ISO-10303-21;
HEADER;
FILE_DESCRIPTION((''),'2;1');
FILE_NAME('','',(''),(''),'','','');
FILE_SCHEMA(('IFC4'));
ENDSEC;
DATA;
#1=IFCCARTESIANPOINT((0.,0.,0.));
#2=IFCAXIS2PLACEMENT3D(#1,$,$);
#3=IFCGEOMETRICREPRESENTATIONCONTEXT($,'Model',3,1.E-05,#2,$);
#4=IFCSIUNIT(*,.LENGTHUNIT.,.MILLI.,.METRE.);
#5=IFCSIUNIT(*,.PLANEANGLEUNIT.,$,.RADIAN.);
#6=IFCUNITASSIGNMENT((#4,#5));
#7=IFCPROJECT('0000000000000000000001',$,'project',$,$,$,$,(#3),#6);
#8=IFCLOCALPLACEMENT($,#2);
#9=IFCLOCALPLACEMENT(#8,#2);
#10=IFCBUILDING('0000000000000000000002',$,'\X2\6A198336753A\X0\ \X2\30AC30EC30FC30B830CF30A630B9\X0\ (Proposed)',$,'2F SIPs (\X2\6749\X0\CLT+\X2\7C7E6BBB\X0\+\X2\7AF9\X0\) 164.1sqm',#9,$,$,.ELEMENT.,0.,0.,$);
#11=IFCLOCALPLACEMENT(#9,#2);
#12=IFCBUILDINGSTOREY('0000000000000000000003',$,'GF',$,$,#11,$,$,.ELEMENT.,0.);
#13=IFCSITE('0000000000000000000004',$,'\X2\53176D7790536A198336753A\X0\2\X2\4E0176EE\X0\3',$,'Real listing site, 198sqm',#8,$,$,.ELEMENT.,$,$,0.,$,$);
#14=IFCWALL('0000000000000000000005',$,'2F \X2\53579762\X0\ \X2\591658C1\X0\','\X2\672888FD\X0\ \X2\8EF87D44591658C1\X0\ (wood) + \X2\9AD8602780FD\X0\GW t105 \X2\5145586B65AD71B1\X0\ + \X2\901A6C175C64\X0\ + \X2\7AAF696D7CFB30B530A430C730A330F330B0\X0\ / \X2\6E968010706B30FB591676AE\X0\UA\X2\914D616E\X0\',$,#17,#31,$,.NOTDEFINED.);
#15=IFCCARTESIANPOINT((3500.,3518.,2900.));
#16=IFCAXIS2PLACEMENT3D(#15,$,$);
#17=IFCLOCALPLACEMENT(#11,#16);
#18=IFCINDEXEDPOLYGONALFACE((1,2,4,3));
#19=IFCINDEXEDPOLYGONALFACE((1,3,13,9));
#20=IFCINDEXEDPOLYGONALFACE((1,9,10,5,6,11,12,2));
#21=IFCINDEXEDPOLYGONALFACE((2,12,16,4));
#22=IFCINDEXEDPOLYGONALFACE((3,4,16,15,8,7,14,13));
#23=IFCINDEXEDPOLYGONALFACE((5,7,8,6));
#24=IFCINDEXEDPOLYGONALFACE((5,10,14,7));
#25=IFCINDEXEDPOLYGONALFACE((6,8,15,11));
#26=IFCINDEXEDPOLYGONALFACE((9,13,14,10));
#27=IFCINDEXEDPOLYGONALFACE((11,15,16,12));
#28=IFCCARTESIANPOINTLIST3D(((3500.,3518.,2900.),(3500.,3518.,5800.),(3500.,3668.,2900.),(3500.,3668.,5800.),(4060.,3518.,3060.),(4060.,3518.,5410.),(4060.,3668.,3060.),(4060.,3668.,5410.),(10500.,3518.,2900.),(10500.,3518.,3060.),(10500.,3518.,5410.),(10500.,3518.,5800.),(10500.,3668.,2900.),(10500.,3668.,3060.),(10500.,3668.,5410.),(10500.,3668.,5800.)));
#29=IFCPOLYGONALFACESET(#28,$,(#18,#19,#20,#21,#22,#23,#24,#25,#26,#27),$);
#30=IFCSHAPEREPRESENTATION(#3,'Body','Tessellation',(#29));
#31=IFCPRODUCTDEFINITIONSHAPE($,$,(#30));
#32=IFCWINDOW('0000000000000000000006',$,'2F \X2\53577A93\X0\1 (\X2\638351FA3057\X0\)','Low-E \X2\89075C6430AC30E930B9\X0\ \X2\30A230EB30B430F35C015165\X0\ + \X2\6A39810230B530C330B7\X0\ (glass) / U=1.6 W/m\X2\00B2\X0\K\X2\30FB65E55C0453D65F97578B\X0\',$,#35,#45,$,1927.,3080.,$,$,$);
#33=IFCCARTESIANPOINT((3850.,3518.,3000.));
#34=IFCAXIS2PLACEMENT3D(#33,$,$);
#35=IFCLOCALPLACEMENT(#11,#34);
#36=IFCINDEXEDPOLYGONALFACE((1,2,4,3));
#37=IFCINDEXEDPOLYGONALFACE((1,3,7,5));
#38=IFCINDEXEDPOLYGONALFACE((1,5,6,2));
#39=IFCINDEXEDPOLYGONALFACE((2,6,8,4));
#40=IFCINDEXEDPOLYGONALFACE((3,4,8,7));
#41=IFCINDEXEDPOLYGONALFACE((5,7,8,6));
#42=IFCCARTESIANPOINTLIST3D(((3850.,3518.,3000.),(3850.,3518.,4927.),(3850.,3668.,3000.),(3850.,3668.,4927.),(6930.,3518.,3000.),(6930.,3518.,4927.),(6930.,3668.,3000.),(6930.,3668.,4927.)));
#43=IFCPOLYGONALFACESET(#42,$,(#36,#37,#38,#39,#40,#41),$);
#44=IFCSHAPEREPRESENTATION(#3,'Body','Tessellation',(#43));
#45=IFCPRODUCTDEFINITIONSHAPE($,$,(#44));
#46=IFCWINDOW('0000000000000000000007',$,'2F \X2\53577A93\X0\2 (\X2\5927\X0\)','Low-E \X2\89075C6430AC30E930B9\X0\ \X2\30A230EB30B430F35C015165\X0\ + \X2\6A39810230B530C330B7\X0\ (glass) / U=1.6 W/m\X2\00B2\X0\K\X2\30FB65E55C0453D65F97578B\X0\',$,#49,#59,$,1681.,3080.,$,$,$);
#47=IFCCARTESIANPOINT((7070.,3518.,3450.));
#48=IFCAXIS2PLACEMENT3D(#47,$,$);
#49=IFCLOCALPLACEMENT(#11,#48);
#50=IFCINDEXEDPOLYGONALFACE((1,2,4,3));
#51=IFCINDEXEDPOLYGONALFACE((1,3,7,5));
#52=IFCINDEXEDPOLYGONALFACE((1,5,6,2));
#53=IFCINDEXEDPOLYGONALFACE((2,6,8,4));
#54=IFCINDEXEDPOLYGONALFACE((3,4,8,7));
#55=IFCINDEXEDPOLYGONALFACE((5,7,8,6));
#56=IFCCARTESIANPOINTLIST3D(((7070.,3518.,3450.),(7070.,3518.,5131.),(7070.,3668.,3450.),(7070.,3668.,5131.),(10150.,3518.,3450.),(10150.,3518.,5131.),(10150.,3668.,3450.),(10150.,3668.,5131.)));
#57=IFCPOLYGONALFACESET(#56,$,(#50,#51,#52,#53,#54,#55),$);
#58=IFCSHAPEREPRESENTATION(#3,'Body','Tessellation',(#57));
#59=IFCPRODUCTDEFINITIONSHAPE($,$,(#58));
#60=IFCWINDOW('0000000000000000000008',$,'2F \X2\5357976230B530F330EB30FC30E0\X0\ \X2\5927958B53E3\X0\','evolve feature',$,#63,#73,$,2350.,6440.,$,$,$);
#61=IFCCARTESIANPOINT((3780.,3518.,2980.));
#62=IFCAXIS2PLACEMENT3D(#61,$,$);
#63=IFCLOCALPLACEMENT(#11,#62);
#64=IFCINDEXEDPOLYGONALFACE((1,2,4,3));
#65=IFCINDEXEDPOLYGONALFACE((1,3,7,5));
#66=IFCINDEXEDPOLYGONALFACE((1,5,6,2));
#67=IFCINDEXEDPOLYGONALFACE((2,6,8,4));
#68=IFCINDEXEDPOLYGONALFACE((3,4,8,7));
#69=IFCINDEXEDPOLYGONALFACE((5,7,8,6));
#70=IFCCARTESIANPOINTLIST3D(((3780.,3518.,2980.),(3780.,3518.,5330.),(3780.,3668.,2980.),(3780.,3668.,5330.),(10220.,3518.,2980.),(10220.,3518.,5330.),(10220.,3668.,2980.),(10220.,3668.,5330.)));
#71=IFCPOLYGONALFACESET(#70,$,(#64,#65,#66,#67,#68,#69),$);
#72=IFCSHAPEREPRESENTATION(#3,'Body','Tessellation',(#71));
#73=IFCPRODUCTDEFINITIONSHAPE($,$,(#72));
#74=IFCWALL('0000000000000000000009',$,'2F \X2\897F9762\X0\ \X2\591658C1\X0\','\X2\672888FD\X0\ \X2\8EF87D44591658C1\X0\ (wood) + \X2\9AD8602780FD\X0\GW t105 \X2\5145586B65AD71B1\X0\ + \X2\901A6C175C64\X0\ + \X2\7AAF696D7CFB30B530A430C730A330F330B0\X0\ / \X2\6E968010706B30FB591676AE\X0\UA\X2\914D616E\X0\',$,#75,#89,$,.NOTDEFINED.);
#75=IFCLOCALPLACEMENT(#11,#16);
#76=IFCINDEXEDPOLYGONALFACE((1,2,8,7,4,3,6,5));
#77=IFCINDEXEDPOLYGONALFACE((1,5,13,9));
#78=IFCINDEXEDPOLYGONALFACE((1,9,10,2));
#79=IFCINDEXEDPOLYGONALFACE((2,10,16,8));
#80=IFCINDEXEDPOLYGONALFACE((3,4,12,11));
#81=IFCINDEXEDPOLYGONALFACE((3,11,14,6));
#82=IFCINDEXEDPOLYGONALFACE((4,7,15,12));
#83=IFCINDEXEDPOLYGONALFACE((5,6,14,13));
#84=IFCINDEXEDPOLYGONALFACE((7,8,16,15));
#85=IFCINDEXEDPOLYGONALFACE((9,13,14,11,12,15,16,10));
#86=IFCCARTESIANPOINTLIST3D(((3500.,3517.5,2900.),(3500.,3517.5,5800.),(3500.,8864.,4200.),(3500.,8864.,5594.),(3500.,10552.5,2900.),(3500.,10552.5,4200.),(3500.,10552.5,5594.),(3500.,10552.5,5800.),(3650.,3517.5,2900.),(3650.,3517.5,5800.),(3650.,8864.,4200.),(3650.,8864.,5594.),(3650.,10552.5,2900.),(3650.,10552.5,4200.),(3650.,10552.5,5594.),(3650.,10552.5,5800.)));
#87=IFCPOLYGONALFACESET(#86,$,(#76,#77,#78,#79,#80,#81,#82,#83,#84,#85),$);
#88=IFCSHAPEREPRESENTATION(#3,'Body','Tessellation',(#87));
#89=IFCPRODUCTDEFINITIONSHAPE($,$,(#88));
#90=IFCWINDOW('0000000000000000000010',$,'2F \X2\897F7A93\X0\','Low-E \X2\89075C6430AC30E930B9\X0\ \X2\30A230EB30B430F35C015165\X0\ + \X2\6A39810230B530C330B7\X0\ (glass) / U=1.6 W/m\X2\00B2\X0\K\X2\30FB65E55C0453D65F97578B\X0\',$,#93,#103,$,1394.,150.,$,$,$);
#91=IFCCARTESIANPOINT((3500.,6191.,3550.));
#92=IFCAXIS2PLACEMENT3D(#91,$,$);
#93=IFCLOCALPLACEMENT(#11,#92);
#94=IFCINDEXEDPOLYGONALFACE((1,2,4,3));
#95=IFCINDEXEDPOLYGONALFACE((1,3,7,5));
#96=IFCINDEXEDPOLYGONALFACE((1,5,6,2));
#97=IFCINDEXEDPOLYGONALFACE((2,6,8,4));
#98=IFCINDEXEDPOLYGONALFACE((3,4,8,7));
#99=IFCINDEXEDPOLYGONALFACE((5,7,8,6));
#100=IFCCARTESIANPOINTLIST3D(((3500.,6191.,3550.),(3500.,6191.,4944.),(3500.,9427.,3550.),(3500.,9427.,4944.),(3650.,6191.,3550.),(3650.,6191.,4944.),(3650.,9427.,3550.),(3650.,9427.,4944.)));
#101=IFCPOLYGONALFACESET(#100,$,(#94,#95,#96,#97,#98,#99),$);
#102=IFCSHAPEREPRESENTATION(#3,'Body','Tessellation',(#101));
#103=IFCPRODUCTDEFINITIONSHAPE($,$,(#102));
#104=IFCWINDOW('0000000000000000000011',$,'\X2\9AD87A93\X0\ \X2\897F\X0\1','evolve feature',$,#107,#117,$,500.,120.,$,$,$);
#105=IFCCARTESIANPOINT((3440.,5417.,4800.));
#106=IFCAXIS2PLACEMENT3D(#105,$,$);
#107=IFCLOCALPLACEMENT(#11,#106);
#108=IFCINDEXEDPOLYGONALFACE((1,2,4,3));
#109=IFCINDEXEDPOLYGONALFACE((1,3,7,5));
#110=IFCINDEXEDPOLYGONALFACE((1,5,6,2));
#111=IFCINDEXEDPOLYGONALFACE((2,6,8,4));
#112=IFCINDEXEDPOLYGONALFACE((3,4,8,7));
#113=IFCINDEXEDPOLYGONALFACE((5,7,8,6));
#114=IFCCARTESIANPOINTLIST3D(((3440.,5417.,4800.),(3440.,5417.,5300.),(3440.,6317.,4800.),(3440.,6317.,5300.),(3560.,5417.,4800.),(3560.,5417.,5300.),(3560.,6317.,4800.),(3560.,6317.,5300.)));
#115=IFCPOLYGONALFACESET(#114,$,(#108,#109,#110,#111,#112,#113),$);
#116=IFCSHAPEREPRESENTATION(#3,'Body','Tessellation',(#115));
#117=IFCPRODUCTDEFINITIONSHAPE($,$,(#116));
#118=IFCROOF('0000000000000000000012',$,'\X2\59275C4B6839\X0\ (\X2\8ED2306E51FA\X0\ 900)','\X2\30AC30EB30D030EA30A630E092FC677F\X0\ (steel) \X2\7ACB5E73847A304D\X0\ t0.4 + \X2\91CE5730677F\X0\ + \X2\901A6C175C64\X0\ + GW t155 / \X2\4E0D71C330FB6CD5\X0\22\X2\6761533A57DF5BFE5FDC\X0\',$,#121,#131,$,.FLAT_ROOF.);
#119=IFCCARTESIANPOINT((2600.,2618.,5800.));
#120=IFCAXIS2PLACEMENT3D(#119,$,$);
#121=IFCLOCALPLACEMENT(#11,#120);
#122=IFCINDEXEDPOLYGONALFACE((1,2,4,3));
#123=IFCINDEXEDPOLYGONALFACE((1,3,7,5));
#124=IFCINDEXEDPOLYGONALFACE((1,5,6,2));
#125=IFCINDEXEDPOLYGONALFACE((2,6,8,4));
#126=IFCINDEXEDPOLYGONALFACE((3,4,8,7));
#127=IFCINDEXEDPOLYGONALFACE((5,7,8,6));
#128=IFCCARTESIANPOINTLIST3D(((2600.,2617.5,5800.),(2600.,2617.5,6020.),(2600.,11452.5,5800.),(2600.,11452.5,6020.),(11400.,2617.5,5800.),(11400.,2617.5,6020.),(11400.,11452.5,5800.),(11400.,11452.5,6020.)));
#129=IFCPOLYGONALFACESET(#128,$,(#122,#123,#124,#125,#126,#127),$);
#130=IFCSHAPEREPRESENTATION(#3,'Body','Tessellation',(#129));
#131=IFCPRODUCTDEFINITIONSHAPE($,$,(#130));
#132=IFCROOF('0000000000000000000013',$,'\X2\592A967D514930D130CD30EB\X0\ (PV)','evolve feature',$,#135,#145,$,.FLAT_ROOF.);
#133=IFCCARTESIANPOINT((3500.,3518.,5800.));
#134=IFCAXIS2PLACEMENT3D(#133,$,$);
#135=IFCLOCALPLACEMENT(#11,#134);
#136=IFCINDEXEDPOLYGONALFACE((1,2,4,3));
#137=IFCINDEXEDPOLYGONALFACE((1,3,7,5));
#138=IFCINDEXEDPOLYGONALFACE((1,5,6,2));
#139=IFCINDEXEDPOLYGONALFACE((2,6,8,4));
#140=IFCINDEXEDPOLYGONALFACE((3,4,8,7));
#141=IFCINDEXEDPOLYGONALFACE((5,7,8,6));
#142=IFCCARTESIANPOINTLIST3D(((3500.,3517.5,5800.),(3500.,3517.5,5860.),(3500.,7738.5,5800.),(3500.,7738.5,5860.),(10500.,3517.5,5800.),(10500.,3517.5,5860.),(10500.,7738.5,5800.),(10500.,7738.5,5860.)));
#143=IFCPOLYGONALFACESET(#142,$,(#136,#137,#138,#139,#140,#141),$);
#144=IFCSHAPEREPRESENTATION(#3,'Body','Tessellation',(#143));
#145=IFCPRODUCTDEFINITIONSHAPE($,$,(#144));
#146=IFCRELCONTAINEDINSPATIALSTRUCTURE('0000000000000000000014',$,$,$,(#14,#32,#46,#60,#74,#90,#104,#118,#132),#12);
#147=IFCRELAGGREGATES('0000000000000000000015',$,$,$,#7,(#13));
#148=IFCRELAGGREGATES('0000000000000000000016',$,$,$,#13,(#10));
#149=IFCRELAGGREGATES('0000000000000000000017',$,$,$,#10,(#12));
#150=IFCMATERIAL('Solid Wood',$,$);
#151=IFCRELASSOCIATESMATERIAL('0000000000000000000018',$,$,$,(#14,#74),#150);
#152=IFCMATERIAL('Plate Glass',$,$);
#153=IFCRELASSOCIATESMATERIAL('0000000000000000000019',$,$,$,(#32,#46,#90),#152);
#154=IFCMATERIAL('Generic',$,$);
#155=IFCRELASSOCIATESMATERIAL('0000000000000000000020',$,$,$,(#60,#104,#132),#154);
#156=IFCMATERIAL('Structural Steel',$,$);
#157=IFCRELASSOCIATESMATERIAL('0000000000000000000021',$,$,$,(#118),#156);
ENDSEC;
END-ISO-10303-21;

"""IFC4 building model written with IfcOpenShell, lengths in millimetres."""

from ifc_helpers import new_model, si_unit, frame, frame_2d, origin, place, context, project, spatial, rectangle, extrude, material, element, fill, save


model = new_model("IFC4")

# Units and contexts
model_context = context("Model", 3, precision=1e-05, world=origin())
ifc_project = project(units=[si_unit("LENGTHUNIT", "METRE", prefix="MILLI"), si_unit("PLANEANGLEUNIT", "RADIAN")], contexts=[model_context])

# Site, building, storey
site_placement = place(None, origin())
site = spatial("IfcSite", under=ifc_project, at=site_placement, Name="北海道標茶町2丁目3", ObjectType="Real listing site, 198sqm", CompositionType="ELEMENT", RefElevation=0.0)
building_placement = place(site_placement, origin())
building = spatial("IfcBuilding", under=site, at=building_placement, Name="標茶町 ガレージハウス (Proposed)", ObjectType="2F SIPs (杉CLT+籾殻+竹) 164.1sqm", CompositionType="ELEMENT", ElevationOfRefHeight=0.0, ElevationOfTerrain=0.0)
storey_placement = place(building_placement, origin())
storey = spatial("IfcBuildingStorey", under=building, at=storey_placement, Name="GF", CompositionType="ELEMENT", Elevation=0.0)

# Shared definitions
ifc_material_1 = material(Name="Solid Wood")
ifc_material_2 = material(Name="Generic")

# Shared definitions
ifc_material_3 = material(Name="Plate Glass")

# Walls, openings, windows
wall_1_placement = place(storey_placement, frame((3500.0, 3518.0, 2900.0)))
wall_1 = element("IfcWall", 1, at=wall_1_placement, inside=storey, material=ifc_material_1, Name="2F 南面 外壁", Description="木製 軸組外壁 (wood) + 高性能GW t105 充填断熱 + 通気層 + 窯業系サイディング / 準耐火・外皮UA配慮", PredefinedType="NOTDEFINED", context=model_context, shape_type="SweptSolid", body=[
    extrude(rectangle(XDim=7000.0, YDim=150.0, at=frame_2d((3500.0, 75.0))), frame((3500.0, 3518.0, 2900.0)), (0.0, 0.0, 1.0), 2900.0),
])
opening_1_placement = place(storey_placement, frame((3850.0, 3518.0, 3000.0)))
opening_1 = element("IfcOpeningElement", 2, at=opening_1_placement, cuts=wall_1, PredefinedType="NOTDEFINED", context=model_context, shape_type="SweptSolid", body=[
    extrude(rectangle(XDim=3080.0, YDim=150.0, at=frame_2d((1540.0, 75.0))), frame((3850.0, 3518.0, 3000.0)), (0.0, 0.0, 1.0), 1927.0),
])
opening_2_placement = place(storey_placement, frame((7070.0, 3518.0, 3450.0)))
opening_2 = element("IfcOpeningElement", 3, at=opening_2_placement, cuts=wall_1, PredefinedType="NOTDEFINED", context=model_context, shape_type="SweptSolid", body=[
    extrude(rectangle(XDim=3080.0, YDim=150.0, at=frame_2d((1540.0, 75.0))), frame((7070.0, 3518.0, 3450.0)), (0.0, 0.0, 1.0), 1681.0),
])
opening_3_placement = place(storey_placement, frame((3780.0, 3518.0, 2980.0)))
opening_3 = element("IfcOpeningElement", 4, at=opening_3_placement, cuts=wall_1, PredefinedType="NOTDEFINED", context=model_context, shape_type="SweptSolid", body=[
    extrude(rectangle(XDim=6440.0, YDim=150.0, at=frame_2d((3220.0, 75.0))), frame((3780.0, 3518.0, 2980.0)), (0.0, 0.0, 1.0), 2350.0),
])
window_1_placement = place(storey_placement, frame((3850.0, 3518.0, 3000.0)))
window_1 = element("IfcWindow", 5, at=window_1_placement, inside=storey, material=ifc_material_3, Name="2F 南窓1 (掃出し)", Description="Low-E 複層ガラス アルゴン封入 + 樹脂サッシ (glass) / U=1.6 W/m²K・日射取得型", OverallHeight=1927.0, OverallWidth=3080.0, context=model_context, shape_type="SweptSolid", body=[
    extrude(rectangle(XDim=3080.0, YDim=150.0, at=frame_2d((1540.0, 75.0))), frame((3850.0, 3518.0, 3000.0)), (0.0, 0.0, 1.0), 1927.0),
])
fill(opening_1, window_1)
window_2_placement = place(storey_placement, frame((7070.0, 3518.0, 3450.0)))
window_2 = element("IfcWindow", 6, at=window_2_placement, inside=storey, material=ifc_material_3, Name="2F 南窓2 (大)", Description="Low-E 複層ガラス アルゴン封入 + 樹脂サッシ (glass) / U=1.6 W/m²K・日射取得型", OverallHeight=1681.0, OverallWidth=3080.0, context=model_context, shape_type="SweptSolid", body=[
    extrude(rectangle(XDim=3080.0, YDim=150.0, at=frame_2d((1540.0, 75.0))), frame((7070.0, 3518.0, 3450.0)), (0.0, 0.0, 1.0), 1681.0),
])
fill(opening_2, window_2)
window_3_placement = place(storey_placement, frame((3780.0, 3518.0, 2980.0)))
window_3 = element("IfcWindow", 7, at=window_3_placement, inside=storey, material=ifc_material_2, Name="2F 南面サンルーム 大開口", Description="evolve feature", OverallHeight=2350.0, OverallWidth=6440.0, context=model_context, shape_type="SweptSolid", body=[
    extrude(rectangle(XDim=6440.0, YDim=150.0, at=frame_2d((3220.0, 75.0))), frame((3780.0, 3518.0, 2980.0)), (0.0, 0.0, 1.0), 2350.0),
])
fill(opening_3, window_3)
wall_2_placement = place(storey_placement, frame((3500.0, 3518.0, 2900.0)))
wall_2 = element("IfcWall", 8, at=wall_2_placement, inside=storey, material=ifc_material_1, Name="2F 西面 外壁", Description="木製 軸組外壁 (wood) + 高性能GW t105 充填断熱 + 通気層 + 窯業系サイディング / 準耐火・外皮UA配慮", PredefinedType="NOTDEFINED", context=model_context, shape_type="SweptSolid", body=[
    extrude(rectangle(XDim=150.0, YDim=7035.0, at=frame_2d((75.0, 3517.0))), frame((3500.0, 3518.0, 2900.0)), (0.0, 0.0, 1.0), 2900.0),
])
opening_4_placement = place(storey_placement, frame((3500.0, 6191.0, 3550.0)))
opening_4 = element("IfcOpeningElement", 9, at=opening_4_placement, cuts=wall_2, PredefinedType="NOTDEFINED", context=model_context, shape_type="SweptSolid", body=[
    extrude(rectangle(XDim=150.0, YDim=3236.0, at=frame_2d((75.0, 1618.0))), frame((3500.0, 6191.0, 3550.0)), (0.0, 0.0, 1.0), 1394.0),
])
opening_5_placement = place(storey_placement, frame((3440.0, 5417.0, 4800.0)))
opening_5 = element("IfcOpeningElement", 10, at=opening_5_placement, cuts=wall_2, PredefinedType="NOTDEFINED", context=model_context, shape_type="SweptSolid", body=[
    extrude(rectangle(XDim=120.0, YDim=900.0, at=frame_2d((60.0, 450.0))), frame((3440.0, 5417.0, 4800.0)), (0.0, 0.0, 1.0), 500.0),
])
window_4_placement = place(storey_placement, frame((3500.0, 6191.0, 3550.0)))
window_4 = element("IfcWindow", 11, at=window_4_placement, inside=storey, material=ifc_material_3, Name="2F 西窓", Description="Low-E 複層ガラス アルゴン封入 + 樹脂サッシ (glass) / U=1.6 W/m²K・日射取得型", OverallHeight=1394.0, OverallWidth=150.0, context=model_context, shape_type="SweptSolid", body=[
    extrude(rectangle(XDim=150.0, YDim=3236.0, at=frame_2d((75.0, 1618.0))), frame((3500.0, 6191.0, 3550.0)), (0.0, 0.0, 1.0), 1394.0),
])
fill(opening_4, window_4)
window_5_placement = place(storey_placement, frame((3440.0, 5417.0, 4800.0)))
window_5 = element("IfcWindow", 12, at=window_5_placement, inside=storey, material=ifc_material_2, Name="高窓 西1", Description="evolve feature", OverallHeight=500.0, OverallWidth=120.0, context=model_context, shape_type="SweptSolid", body=[
    extrude(rectangle(XDim=120.0, YDim=900.0, at=frame_2d((60.0, 450.0))), frame((3440.0, 5417.0, 4800.0)), (0.0, 0.0, 1.0), 500.0),
])
fill(opening_5, window_5)

# Roofs
ifc_material_4 = material(Name="Structural Steel")
roof_1_placement = place(storey_placement, frame((2600.0, 2618.0, 5800.0)))
element("IfcRoof", 13, at=roof_1_placement, inside=storey, material=ifc_material_4, Name="大屋根 (軒の出 900)", Description="ガルバリウム鋼板 (steel) 立平葺き t0.4 + 野地板 + 通気層 + GW t155 / 不燃・法22条区域対応", PredefinedType="FLAT_ROOF", context=model_context, shape_type="SweptSolid", body=[
    extrude(rectangle(XDim=8800.0, YDim=8835.0, at=frame_2d((4400.0, 4417.0))), frame((2600.0, 2618.0, 5800.0)), (0.0, 0.0, 1.0), 220.0),
])
roof_2_placement = place(storey_placement, frame((3500.0, 3518.0, 5800.0)))
element("IfcRoof", 14, at=roof_2_placement, inside=storey, material=ifc_material_2, Name="太陽光パネル (PV)", Description="evolve feature", PredefinedType="FLAT_ROOF", context=model_context, shape_type="SweptSolid", body=[
    extrude(rectangle(XDim=7000.0, YDim=4221.0, at=frame_2d((3500.0, 2110.0))), frame((3500.0, 3518.0, 5800.0)), (0.0, 0.0, 1.0), 60.0),
])

save(model, "model.ifc")
